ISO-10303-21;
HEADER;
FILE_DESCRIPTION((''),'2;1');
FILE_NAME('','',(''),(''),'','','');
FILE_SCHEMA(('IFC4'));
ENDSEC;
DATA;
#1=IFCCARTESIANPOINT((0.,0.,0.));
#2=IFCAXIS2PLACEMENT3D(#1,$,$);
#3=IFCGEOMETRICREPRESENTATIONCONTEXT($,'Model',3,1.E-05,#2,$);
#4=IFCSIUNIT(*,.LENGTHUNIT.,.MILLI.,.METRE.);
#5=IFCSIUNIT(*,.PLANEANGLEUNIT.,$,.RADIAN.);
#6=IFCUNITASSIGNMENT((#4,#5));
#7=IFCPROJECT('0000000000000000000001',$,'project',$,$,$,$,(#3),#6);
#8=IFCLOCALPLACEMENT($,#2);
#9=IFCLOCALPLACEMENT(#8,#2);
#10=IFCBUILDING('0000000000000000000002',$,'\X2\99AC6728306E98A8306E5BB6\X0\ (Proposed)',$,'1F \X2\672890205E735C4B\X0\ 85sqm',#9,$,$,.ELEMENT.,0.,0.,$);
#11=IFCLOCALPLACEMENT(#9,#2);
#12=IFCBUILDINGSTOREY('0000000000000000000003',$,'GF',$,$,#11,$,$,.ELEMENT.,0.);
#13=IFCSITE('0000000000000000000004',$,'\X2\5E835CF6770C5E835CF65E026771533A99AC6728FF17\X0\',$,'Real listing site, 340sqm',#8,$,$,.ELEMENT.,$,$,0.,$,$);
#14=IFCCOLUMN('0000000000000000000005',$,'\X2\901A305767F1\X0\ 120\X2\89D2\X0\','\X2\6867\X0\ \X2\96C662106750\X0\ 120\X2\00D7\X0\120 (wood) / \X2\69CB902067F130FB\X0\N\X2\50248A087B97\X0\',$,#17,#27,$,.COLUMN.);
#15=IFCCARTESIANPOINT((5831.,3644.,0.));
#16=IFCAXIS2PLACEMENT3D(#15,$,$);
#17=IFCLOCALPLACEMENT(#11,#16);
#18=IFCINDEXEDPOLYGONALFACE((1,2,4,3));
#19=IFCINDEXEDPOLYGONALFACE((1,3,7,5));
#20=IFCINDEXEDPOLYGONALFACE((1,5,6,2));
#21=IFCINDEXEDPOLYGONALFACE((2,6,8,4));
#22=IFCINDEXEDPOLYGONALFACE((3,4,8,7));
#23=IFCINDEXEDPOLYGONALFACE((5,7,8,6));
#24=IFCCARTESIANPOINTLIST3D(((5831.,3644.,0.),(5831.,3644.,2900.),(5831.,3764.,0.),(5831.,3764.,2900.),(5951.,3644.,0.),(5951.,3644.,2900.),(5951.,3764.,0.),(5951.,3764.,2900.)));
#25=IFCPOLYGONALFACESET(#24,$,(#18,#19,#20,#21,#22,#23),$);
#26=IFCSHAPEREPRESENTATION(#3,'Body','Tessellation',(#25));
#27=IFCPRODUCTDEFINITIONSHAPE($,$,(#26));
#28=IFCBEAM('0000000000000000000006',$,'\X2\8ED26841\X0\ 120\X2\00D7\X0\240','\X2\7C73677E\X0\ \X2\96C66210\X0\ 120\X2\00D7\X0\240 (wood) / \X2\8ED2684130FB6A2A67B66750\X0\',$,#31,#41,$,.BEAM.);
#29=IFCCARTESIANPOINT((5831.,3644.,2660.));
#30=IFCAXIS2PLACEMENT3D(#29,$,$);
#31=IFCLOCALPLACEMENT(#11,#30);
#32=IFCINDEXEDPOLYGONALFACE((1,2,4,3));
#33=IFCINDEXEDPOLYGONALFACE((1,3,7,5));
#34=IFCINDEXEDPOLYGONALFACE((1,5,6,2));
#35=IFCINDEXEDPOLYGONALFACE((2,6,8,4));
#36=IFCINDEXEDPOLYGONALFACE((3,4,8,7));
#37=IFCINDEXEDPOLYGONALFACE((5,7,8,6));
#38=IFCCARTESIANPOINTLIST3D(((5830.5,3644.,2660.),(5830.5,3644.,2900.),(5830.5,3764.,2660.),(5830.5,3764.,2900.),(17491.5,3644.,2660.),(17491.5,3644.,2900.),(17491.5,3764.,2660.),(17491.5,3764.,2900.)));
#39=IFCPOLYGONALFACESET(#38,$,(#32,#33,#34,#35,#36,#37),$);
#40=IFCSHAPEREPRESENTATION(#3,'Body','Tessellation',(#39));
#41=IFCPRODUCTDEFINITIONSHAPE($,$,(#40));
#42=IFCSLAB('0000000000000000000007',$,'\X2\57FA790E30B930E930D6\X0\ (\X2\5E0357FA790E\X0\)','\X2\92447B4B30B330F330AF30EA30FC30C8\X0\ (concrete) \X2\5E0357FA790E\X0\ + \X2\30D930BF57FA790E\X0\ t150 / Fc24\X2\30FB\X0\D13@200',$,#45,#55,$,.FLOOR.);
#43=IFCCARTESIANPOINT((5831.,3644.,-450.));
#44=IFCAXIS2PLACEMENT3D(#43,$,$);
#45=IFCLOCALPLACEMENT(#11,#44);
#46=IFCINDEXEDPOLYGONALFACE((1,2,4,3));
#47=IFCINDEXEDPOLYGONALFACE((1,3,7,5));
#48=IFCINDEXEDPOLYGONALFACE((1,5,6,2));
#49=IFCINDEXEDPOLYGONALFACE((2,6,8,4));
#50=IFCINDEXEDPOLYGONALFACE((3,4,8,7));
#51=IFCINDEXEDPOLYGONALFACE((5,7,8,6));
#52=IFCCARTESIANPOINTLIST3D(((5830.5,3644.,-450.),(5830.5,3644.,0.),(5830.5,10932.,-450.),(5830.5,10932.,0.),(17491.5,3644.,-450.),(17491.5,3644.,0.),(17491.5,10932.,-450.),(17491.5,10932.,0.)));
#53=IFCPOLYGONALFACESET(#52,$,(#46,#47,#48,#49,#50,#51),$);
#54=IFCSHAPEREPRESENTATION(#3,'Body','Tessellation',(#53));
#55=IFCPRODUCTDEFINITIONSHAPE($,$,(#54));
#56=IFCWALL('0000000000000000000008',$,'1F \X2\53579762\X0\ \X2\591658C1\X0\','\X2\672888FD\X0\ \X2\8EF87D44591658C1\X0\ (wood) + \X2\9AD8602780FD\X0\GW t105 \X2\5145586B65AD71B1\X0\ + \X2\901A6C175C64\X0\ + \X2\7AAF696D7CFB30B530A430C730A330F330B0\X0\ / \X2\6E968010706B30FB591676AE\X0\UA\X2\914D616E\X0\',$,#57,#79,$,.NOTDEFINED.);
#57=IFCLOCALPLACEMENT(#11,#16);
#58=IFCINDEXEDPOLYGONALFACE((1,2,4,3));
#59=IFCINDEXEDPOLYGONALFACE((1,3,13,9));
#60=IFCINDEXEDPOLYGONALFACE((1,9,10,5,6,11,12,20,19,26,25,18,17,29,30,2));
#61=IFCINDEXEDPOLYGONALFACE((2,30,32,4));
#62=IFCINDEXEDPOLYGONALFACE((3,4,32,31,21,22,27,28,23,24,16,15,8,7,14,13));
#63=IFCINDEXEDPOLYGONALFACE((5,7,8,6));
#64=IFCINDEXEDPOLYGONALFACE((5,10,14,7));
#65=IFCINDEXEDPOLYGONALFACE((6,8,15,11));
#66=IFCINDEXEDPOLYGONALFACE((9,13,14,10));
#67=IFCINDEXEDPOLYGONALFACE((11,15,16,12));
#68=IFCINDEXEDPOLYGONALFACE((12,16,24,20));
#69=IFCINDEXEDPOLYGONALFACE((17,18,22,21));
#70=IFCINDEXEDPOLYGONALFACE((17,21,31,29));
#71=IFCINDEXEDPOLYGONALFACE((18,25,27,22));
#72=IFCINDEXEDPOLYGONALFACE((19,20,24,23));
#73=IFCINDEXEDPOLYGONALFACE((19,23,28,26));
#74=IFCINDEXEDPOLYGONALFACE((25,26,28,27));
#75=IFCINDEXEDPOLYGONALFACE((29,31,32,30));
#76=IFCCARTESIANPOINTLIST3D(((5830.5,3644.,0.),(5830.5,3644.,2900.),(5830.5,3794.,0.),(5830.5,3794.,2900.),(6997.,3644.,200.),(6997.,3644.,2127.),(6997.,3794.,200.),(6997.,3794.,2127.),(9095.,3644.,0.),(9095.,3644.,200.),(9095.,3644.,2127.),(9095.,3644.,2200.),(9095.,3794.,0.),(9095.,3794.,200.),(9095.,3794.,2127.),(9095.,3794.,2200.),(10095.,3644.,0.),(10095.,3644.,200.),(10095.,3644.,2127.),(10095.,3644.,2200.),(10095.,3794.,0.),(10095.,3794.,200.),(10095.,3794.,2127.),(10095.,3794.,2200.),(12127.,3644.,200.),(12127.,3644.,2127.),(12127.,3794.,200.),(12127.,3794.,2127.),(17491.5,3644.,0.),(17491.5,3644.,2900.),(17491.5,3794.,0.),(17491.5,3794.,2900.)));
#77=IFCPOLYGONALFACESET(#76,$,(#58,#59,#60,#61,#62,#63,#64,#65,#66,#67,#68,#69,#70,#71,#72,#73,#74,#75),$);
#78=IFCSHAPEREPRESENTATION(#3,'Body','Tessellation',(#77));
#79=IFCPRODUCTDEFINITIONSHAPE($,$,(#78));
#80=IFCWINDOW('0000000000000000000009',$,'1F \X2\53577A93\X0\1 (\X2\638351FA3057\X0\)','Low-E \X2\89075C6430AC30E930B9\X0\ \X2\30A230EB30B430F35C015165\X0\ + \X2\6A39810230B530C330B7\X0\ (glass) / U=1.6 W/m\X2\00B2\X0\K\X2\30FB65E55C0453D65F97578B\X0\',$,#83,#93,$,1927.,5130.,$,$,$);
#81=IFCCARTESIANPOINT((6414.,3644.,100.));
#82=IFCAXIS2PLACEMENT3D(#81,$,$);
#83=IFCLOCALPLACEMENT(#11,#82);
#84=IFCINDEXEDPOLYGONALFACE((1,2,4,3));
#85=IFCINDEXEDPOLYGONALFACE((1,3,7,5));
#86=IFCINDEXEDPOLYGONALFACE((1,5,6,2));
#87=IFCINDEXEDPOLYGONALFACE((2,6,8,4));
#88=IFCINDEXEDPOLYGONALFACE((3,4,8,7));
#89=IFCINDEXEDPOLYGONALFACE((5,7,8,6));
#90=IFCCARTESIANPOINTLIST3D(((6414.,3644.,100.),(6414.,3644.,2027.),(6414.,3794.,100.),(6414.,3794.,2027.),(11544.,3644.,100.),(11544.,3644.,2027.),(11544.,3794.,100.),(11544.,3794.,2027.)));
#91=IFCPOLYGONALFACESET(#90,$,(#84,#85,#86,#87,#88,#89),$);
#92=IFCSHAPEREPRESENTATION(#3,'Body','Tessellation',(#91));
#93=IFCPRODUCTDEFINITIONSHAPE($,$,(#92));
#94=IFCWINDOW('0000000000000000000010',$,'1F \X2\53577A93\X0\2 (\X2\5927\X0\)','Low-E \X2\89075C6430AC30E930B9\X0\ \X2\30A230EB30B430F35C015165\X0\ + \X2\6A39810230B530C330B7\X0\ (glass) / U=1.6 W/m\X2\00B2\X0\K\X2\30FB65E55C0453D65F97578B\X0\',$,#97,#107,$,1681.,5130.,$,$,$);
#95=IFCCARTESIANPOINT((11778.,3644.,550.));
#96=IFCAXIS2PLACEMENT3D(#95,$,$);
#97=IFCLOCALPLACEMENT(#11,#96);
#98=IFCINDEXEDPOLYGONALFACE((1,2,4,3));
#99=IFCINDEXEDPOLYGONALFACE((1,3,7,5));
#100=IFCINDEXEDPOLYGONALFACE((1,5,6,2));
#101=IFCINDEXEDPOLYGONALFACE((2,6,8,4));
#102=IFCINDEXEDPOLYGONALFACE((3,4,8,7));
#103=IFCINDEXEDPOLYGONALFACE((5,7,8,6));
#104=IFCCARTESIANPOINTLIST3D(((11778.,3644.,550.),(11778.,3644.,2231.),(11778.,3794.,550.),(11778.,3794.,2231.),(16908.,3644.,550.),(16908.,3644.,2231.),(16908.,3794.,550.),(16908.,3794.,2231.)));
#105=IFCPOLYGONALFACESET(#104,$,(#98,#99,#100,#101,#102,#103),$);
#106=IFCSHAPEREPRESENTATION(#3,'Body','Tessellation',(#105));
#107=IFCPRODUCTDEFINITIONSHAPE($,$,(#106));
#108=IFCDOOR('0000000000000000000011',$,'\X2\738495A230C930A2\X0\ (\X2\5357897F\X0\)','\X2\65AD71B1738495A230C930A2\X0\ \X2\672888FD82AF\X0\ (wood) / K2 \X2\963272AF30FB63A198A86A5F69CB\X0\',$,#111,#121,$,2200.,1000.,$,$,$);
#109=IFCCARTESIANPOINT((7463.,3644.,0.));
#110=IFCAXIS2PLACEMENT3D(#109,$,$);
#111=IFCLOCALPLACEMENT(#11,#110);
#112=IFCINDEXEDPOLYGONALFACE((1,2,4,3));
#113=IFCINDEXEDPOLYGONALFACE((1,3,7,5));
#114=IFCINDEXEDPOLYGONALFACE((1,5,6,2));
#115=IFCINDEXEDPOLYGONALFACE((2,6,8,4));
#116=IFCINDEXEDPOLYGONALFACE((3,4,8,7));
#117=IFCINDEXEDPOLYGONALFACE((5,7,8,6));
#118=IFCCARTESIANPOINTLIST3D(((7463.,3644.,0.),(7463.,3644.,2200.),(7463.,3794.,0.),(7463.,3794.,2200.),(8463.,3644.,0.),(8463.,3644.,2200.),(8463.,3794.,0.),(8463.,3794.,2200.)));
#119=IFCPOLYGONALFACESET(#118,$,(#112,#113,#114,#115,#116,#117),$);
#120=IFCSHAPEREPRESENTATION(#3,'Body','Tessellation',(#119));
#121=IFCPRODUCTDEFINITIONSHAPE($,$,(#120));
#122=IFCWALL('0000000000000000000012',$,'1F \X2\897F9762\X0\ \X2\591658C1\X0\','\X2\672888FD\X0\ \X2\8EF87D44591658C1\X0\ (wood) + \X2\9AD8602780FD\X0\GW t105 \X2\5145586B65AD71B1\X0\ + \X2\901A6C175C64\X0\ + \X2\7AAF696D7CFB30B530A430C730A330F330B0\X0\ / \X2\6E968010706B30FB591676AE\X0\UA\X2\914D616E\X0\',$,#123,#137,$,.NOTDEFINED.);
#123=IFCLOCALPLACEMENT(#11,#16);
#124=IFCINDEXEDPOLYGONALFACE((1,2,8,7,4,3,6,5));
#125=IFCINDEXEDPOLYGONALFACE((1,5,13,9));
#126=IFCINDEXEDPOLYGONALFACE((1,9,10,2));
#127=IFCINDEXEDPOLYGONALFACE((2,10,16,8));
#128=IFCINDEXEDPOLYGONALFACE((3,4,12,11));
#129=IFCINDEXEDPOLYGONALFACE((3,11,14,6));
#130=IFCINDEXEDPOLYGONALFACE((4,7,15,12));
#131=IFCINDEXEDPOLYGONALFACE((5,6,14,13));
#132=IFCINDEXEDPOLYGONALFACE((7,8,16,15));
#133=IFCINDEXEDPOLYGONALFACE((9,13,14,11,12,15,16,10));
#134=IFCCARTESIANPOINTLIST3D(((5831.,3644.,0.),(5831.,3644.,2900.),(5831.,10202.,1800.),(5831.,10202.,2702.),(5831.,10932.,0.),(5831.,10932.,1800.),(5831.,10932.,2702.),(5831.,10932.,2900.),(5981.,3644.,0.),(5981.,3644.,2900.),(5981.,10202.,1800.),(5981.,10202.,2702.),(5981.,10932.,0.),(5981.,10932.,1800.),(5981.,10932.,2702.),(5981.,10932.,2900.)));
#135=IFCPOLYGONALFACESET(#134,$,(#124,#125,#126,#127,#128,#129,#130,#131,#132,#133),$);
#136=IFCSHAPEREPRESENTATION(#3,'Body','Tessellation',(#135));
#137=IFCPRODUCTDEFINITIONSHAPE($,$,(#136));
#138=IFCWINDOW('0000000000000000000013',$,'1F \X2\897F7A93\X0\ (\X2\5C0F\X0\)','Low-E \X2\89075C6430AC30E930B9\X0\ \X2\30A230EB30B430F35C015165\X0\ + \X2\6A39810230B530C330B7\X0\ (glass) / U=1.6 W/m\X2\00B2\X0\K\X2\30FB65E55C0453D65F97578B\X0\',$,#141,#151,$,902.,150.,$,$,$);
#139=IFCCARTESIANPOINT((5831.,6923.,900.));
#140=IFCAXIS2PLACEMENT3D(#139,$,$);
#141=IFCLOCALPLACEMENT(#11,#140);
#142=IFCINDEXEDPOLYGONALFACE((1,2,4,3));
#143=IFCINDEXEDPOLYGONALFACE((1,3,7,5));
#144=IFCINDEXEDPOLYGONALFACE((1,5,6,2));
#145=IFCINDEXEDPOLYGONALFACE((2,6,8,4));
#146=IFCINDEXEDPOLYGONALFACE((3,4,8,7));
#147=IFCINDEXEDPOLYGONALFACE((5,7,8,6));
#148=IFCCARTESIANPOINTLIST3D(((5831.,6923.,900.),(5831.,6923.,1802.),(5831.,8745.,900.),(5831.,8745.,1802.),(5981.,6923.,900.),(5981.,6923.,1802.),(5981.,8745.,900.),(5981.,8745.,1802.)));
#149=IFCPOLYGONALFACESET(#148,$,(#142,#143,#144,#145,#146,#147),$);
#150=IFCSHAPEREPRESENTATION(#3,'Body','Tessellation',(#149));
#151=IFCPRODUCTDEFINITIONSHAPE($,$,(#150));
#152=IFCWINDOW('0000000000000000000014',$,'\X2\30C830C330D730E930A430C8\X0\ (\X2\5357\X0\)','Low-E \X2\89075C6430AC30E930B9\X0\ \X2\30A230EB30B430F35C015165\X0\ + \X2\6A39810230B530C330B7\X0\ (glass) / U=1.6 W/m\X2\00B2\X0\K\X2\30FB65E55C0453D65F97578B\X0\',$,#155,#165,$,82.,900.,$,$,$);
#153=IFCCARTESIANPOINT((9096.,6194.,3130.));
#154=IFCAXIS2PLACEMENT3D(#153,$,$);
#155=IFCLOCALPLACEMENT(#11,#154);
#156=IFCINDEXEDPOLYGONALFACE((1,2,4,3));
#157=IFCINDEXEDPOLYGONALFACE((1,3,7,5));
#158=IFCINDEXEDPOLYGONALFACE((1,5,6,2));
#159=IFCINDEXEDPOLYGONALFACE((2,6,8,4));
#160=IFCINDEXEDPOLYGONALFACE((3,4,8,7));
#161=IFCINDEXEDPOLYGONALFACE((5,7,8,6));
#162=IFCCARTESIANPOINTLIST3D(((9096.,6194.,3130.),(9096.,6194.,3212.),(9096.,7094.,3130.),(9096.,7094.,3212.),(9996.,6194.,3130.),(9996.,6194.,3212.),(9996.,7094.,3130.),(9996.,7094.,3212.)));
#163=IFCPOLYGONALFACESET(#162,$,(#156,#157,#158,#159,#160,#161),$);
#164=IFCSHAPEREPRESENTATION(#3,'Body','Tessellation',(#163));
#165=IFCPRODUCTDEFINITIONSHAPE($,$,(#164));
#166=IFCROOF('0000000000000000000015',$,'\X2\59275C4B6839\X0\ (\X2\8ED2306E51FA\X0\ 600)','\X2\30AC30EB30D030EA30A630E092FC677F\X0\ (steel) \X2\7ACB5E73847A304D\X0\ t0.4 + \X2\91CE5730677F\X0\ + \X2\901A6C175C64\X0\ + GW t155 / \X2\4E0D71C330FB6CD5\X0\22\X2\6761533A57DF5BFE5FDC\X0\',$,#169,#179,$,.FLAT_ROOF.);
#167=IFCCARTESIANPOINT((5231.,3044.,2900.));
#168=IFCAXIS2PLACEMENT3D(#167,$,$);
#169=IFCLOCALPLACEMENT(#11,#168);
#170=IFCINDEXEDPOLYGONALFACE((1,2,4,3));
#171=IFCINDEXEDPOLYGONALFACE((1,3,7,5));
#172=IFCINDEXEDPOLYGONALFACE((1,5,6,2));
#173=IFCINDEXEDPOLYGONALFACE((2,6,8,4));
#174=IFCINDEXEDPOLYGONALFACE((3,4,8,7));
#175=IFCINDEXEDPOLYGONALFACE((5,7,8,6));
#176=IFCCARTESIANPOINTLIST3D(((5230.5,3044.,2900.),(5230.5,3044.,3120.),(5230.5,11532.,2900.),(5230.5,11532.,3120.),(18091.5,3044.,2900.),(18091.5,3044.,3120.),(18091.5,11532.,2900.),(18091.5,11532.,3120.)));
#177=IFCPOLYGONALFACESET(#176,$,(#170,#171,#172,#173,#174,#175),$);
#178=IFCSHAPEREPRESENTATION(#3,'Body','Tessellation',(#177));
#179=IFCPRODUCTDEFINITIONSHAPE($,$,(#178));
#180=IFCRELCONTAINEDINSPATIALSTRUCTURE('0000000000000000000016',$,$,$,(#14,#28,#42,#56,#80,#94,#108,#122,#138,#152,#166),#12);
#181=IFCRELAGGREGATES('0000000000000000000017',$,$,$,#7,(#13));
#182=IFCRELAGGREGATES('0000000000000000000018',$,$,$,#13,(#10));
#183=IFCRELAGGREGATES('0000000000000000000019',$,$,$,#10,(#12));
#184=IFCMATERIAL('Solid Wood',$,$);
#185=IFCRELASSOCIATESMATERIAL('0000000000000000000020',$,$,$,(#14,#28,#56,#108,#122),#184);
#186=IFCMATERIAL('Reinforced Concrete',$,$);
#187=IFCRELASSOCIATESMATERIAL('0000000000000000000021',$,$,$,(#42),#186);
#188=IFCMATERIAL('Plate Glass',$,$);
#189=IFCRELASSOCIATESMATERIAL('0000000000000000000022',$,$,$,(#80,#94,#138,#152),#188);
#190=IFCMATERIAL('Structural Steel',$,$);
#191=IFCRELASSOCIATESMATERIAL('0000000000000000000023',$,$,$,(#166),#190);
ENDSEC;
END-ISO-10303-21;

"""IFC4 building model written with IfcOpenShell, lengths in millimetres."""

from ifc_helpers import new_model, si_unit, frame, frame_2d, origin, place, context, project, spatial, rectangle, extrude, material, element, fill, save


model = new_model("IFC4")

# Units and contexts
model_context = context("Model", 3, precision=1e-05, world=origin())
ifc_project = project(units=[si_unit("LENGTHUNIT", "METRE", prefix="MILLI"), si_unit("PLANEANGLEUNIT", "RADIAN")], contexts=[model_context])

# Site, building, storey
site_placement = place(None, origin())
site = spatial("IfcSite", under=ifc_project, at=site_placement, Name="広島県広島市東区馬木７", ObjectType="Real listing site, 340sqm", CompositionType="ELEMENT", RefElevation=0.0)
building_placement = place(site_placement, origin())
building = spatial("IfcBuilding", under=site, at=building_placement, Name="馬木の風の家 (Proposed)", ObjectType="1F 木造平屋 85sqm", CompositionType="ELEMENT", ElevationOfRefHeight=0.0, ElevationOfTerrain=0.0)
storey_placement = place(building_placement, origin())
storey = spatial("IfcBuildingStorey", under=building, at=storey_placement, Name="GF", CompositionType="ELEMENT", Elevation=0.0)

# Column
ifc_material_1 = material(Name="Solid Wood")
column_1_placement = place(storey_placement, frame((5831.0, 3644.0, 0.0)))
element("IfcColumn", 1, at=column_1_placement, inside=storey, material=ifc_material_1, Name="通し柱 120角", Description="桧 集成材 120×120 (wood) / 構造柱・N値計算", PredefinedType="COLUMN", context=model_context, shape_type="SweptSolid", body=[
    extrude(rectangle(XDim=120.0, YDim=120.0, at=frame_2d((60.0, 60.0))), frame((5831.0, 3644.0, 0.0)), (0.0, 0.0, 1.0), 2900.0),
])

# Beam
beam_1_placement = place(storey_placement, frame((5831.0, 3644.0, 2660.0)))
element("IfcBeam", 2, at=beam_1_placement, inside=storey, material=ifc_material_1, Name="軒桁 120×240", Description="米松 集成 120×240 (wood) / 軒桁・横架材", PredefinedType="BEAM", context=model_context, shape_type="SweptSolid", body=[
    extrude(rectangle(XDim=11661.0, YDim=120.0, at=frame_2d((5830.0, 60.0))), frame((5831.0, 3644.0, 2660.0)), (0.0, 0.0, 1.0), 240.0),
])

# Slab
ifc_material_2 = material(Name="Reinforced Concrete")
slab_1_placement = place(storey_placement, frame((5831.0, 3644.0, -450.0)))
element("IfcSlab", 3, at=slab_1_placement, inside=storey, material=ifc_material_2, Name="基礎スラブ (布基礎)", Description="鉄筋コンクリート (concrete) 布基礎 + ベタ基礎 t150 / Fc24・D13@200", PredefinedType="FLOOR", context=model_context, shape_type="SweptSolid", body=[
    extrude(rectangle(XDim=11661.0, YDim=7288.0, at=frame_2d((5830.0, 3644.0))), frame((5831.0, 3644.0, -450.0)), (0.0, 0.0, 1.0), 450.0),
])

# Wall, openings, windows, door
wall_1_placement = place(storey_placement, frame((5831.0, 3644.0, 0.0)))
wall_1 = element("IfcWall", 4, at=wall_1_placement, inside=storey, material=ifc_material_1, Name="1F 南面 外壁", Description="木製 軸組外壁 (wood) + 高性能GW t105 充填断熱 + 通気層 + 窯業系サイディング / 準耐火・外皮UA配慮", PredefinedType="NOTDEFINED", context=model_context, shape_type="SweptSolid", body=[
    extrude(rectangle(XDim=11661.0, YDim=150.0, at=frame_2d((5830.0, 75.0))), frame((5831.0, 3644.0, 0.0)), (0.0, 0.0, 1.0), 2900.0),
])
opening_1_placement = place(storey_placement, frame((6414.0, 3644.0, 100.0)))
opening_1 = element("IfcOpeningElement", 5, at=opening_1_placement, cuts=wall_1, PredefinedType="NOTDEFINED", context=model_context, shape_type="SweptSolid", body=[
    extrude(rectangle(XDim=5130.0, YDim=150.0, at=frame_2d((2565.0, 75.0))), frame((6414.0, 3644.0, 100.0)), (0.0, 0.0, 1.0), 1927.0),
])
opening_2_placement = place(storey_placement, frame((11778.0, 3644.0, 550.0)))
opening_2 = element("IfcOpeningElement", 6, at=opening_2_placement, cuts=wall_1, PredefinedType="NOTDEFINED", context=model_context, shape_type="SweptSolid", body=[
    extrude(rectangle(XDim=5130.0, YDim=150.0, at=frame_2d((2565.0, 75.0))), frame((11778.0, 3644.0, 550.0)), (0.0, 0.0, 1.0), 1681.0),
])
opening_3_placement = place(storey_placement, frame((7463.0, 3644.0, 0.0)))
opening_3 = element("IfcOpeningElement", 7, at=opening_3_placement, cuts=wall_1, PredefinedType="NOTDEFINED", context=model_context, shape_type="SweptSolid", body=[
    extrude(rectangle(XDim=1000.0, YDim=150.0, at=frame_2d((500.0, 75.0))), frame((7463.0, 3644.0, 0.0)), (0.0, 0.0, 1.0), 2200.0),
])
ifc_material_3 = material(Name="Plate Glass")
window_1_placement = place(storey_placement, frame((6414.0, 3644.0, 100.0)))
window_1 = element("IfcWindow", 8, at=window_1_placement, inside=storey, material=ifc_material_3, Name="1F 南窓1 (掃出し)", Description="Low-E 複層ガラス アルゴン封入 + 樹脂サッシ (glass) / U=1.6 W/m²K・日射取得型", OverallHeight=1927.0, OverallWidth=5130.0, context=model_context, shape_type="SweptSolid", body=[
    extrude(rectangle(XDim=5130.0, YDim=150.0, at=frame_2d((2565.0, 75.0))), frame((6414.0, 3644.0, 100.0)), (0.0, 0.0, 1.0), 1927.0),
])
fill(opening_1, window_1)
window_2_placement = place(storey_placement, frame((11778.0, 3644.0, 550.0)))
window_2 = element("IfcWindow", 9, at=window_2_placement, inside=storey, material=ifc_material_3, Name="1F 南窓2 (大)", Description="Low-E 複層ガラス アルゴン封入 + 樹脂サッシ (glass) / U=1.6 W/m²K・日射取得型", OverallHeight=1681.0, OverallWidth=5130.0, context=model_context, shape_type="SweptSolid", body=[
    extrude(rectangle(XDim=5130.0, YDim=150.0, at=frame_2d((2565.0, 75.0))), frame((11778.0, 3644.0, 550.0)), (0.0, 0.0, 1.0), 1681.0),
])
fill(opening_2, window_2)
door_placement = place(storey_placement, frame((7463.0, 3644.0, 0.0)))
door = element("IfcDoor", 10, at=door_placement, inside=storey, material=ifc_material_1, Name="玄関ドア (南西)", Description="断熱玄関ドア 木製芯 (wood) / K2 防犯・採風機構", OverallHeight=2200.0, OverallWidth=1000.0, context=model_context, shape_type="SweptSolid", body=[
    extrude(rectangle(XDim=1000.0, YDim=150.0, at=frame_2d((500.0, 75.0))), frame((7463.0, 3644.0, 0.0)), (0.0, 0.0, 1.0), 2200.0),
])
fill(opening_3, door)

# Wall, opening, window
wall_2_placement = place(storey_placement, frame((5831.0, 3644.0, 0.0)))
wall_2 = element("IfcWall", 11, at=wall_2_placement, inside=storey, material=ifc_material_1, Name="1F 西面 外壁", Description="木製 軸組外壁 (wood) + 高性能GW t105 充填断熱 + 通気層 + 窯業系サイディング / 準耐火・外皮UA配慮", PredefinedType="NOTDEFINED", context=model_context, shape_type="SweptSolid", body=[
    extrude(rectangle(XDim=150.0, YDim=7288.0, at=frame_2d((75.0, 3644.0))), frame((5831.0, 3644.0, 0.0)), (0.0, 0.0, 1.0), 2900.0),
])
opening_4_placement = place(storey_placement, frame((5831.0, 6923.0, 900.0)))
opening_4 = element("IfcOpeningElement", 12, at=opening_4_placement, cuts=wall_2, PredefinedType="NOTDEFINED", context=model_context, shape_type="SweptSolid", body=[
    extrude(rectangle(XDim=150.0, YDim=1822.0, at=frame_2d((75.0, 911.0))), frame((5831.0, 6923.0, 900.0)), (0.0, 0.0, 1.0), 902.0),
])
window_3_placement = place(storey_placement, frame((5831.0, 6923.0, 900.0)))
window_3 = element("IfcWindow", 13, at=window_3_placement, inside=storey, material=ifc_material_3, Name="1F 西窓 (小)", Description="Low-E 複層ガラス アルゴン封入 + 樹脂サッシ (glass) / U=1.6 W/m²K・日射取得型", OverallHeight=902.0, OverallWidth=150.0, context=model_context, shape_type="SweptSolid", body=[
    extrude(rectangle(XDim=150.0, YDim=1822.0, at=frame_2d((75.0, 911.0))), frame((5831.0, 6923.0, 900.0)), (0.0, 0.0, 1.0), 902.0),
])
fill(opening_4, window_3)

# Window
window_4_placement = place(storey_placement, frame((9096.0, 6194.0, 3130.0)))
element("IfcWindow", 14, at=window_4_placement, inside=storey, material=ifc_material_3, Name="トップライト (南)", Description="Low-E 複層ガラス アルゴン封入 + 樹脂サッシ (glass) / U=1.6 W/m²K・日射取得型", OverallHeight=82.0, OverallWidth=900.0, context=model_context, shape_type="SweptSolid", body=[
    extrude(rectangle(XDim=900.0, YDim=900.0, at=frame_2d((450.0, 450.0))), frame((9096.0, 6194.0, 3130.0)), (0.0, 0.0, 1.0), 82.0),
])

# Roof
ifc_material_4 = material(Name="Structural Steel")
roof_placement = place(storey_placement, frame((5231.0, 3044.0, 2900.0)))
element("IfcRoof", 15, at=roof_placement, inside=storey, material=ifc_material_4, Name="大屋根 (軒の出 600)", Description="ガルバリウム鋼板 (steel) 立平葺き t0.4 + 野地板 + 通気層 + GW t155 / 不燃・法22条区域対応", PredefinedType="FLAT_ROOF", context=model_context, shape_type="SweptSolid", body=[
    extrude(rectangle(XDim=12861.0, YDim=8488.0, at=frame_2d((6430.0, 4244.0))), frame((5231.0, 3044.0, 2900.0)), (0.0, 0.0, 1.0), 220.0),
])

save(model, "model.ifc")
